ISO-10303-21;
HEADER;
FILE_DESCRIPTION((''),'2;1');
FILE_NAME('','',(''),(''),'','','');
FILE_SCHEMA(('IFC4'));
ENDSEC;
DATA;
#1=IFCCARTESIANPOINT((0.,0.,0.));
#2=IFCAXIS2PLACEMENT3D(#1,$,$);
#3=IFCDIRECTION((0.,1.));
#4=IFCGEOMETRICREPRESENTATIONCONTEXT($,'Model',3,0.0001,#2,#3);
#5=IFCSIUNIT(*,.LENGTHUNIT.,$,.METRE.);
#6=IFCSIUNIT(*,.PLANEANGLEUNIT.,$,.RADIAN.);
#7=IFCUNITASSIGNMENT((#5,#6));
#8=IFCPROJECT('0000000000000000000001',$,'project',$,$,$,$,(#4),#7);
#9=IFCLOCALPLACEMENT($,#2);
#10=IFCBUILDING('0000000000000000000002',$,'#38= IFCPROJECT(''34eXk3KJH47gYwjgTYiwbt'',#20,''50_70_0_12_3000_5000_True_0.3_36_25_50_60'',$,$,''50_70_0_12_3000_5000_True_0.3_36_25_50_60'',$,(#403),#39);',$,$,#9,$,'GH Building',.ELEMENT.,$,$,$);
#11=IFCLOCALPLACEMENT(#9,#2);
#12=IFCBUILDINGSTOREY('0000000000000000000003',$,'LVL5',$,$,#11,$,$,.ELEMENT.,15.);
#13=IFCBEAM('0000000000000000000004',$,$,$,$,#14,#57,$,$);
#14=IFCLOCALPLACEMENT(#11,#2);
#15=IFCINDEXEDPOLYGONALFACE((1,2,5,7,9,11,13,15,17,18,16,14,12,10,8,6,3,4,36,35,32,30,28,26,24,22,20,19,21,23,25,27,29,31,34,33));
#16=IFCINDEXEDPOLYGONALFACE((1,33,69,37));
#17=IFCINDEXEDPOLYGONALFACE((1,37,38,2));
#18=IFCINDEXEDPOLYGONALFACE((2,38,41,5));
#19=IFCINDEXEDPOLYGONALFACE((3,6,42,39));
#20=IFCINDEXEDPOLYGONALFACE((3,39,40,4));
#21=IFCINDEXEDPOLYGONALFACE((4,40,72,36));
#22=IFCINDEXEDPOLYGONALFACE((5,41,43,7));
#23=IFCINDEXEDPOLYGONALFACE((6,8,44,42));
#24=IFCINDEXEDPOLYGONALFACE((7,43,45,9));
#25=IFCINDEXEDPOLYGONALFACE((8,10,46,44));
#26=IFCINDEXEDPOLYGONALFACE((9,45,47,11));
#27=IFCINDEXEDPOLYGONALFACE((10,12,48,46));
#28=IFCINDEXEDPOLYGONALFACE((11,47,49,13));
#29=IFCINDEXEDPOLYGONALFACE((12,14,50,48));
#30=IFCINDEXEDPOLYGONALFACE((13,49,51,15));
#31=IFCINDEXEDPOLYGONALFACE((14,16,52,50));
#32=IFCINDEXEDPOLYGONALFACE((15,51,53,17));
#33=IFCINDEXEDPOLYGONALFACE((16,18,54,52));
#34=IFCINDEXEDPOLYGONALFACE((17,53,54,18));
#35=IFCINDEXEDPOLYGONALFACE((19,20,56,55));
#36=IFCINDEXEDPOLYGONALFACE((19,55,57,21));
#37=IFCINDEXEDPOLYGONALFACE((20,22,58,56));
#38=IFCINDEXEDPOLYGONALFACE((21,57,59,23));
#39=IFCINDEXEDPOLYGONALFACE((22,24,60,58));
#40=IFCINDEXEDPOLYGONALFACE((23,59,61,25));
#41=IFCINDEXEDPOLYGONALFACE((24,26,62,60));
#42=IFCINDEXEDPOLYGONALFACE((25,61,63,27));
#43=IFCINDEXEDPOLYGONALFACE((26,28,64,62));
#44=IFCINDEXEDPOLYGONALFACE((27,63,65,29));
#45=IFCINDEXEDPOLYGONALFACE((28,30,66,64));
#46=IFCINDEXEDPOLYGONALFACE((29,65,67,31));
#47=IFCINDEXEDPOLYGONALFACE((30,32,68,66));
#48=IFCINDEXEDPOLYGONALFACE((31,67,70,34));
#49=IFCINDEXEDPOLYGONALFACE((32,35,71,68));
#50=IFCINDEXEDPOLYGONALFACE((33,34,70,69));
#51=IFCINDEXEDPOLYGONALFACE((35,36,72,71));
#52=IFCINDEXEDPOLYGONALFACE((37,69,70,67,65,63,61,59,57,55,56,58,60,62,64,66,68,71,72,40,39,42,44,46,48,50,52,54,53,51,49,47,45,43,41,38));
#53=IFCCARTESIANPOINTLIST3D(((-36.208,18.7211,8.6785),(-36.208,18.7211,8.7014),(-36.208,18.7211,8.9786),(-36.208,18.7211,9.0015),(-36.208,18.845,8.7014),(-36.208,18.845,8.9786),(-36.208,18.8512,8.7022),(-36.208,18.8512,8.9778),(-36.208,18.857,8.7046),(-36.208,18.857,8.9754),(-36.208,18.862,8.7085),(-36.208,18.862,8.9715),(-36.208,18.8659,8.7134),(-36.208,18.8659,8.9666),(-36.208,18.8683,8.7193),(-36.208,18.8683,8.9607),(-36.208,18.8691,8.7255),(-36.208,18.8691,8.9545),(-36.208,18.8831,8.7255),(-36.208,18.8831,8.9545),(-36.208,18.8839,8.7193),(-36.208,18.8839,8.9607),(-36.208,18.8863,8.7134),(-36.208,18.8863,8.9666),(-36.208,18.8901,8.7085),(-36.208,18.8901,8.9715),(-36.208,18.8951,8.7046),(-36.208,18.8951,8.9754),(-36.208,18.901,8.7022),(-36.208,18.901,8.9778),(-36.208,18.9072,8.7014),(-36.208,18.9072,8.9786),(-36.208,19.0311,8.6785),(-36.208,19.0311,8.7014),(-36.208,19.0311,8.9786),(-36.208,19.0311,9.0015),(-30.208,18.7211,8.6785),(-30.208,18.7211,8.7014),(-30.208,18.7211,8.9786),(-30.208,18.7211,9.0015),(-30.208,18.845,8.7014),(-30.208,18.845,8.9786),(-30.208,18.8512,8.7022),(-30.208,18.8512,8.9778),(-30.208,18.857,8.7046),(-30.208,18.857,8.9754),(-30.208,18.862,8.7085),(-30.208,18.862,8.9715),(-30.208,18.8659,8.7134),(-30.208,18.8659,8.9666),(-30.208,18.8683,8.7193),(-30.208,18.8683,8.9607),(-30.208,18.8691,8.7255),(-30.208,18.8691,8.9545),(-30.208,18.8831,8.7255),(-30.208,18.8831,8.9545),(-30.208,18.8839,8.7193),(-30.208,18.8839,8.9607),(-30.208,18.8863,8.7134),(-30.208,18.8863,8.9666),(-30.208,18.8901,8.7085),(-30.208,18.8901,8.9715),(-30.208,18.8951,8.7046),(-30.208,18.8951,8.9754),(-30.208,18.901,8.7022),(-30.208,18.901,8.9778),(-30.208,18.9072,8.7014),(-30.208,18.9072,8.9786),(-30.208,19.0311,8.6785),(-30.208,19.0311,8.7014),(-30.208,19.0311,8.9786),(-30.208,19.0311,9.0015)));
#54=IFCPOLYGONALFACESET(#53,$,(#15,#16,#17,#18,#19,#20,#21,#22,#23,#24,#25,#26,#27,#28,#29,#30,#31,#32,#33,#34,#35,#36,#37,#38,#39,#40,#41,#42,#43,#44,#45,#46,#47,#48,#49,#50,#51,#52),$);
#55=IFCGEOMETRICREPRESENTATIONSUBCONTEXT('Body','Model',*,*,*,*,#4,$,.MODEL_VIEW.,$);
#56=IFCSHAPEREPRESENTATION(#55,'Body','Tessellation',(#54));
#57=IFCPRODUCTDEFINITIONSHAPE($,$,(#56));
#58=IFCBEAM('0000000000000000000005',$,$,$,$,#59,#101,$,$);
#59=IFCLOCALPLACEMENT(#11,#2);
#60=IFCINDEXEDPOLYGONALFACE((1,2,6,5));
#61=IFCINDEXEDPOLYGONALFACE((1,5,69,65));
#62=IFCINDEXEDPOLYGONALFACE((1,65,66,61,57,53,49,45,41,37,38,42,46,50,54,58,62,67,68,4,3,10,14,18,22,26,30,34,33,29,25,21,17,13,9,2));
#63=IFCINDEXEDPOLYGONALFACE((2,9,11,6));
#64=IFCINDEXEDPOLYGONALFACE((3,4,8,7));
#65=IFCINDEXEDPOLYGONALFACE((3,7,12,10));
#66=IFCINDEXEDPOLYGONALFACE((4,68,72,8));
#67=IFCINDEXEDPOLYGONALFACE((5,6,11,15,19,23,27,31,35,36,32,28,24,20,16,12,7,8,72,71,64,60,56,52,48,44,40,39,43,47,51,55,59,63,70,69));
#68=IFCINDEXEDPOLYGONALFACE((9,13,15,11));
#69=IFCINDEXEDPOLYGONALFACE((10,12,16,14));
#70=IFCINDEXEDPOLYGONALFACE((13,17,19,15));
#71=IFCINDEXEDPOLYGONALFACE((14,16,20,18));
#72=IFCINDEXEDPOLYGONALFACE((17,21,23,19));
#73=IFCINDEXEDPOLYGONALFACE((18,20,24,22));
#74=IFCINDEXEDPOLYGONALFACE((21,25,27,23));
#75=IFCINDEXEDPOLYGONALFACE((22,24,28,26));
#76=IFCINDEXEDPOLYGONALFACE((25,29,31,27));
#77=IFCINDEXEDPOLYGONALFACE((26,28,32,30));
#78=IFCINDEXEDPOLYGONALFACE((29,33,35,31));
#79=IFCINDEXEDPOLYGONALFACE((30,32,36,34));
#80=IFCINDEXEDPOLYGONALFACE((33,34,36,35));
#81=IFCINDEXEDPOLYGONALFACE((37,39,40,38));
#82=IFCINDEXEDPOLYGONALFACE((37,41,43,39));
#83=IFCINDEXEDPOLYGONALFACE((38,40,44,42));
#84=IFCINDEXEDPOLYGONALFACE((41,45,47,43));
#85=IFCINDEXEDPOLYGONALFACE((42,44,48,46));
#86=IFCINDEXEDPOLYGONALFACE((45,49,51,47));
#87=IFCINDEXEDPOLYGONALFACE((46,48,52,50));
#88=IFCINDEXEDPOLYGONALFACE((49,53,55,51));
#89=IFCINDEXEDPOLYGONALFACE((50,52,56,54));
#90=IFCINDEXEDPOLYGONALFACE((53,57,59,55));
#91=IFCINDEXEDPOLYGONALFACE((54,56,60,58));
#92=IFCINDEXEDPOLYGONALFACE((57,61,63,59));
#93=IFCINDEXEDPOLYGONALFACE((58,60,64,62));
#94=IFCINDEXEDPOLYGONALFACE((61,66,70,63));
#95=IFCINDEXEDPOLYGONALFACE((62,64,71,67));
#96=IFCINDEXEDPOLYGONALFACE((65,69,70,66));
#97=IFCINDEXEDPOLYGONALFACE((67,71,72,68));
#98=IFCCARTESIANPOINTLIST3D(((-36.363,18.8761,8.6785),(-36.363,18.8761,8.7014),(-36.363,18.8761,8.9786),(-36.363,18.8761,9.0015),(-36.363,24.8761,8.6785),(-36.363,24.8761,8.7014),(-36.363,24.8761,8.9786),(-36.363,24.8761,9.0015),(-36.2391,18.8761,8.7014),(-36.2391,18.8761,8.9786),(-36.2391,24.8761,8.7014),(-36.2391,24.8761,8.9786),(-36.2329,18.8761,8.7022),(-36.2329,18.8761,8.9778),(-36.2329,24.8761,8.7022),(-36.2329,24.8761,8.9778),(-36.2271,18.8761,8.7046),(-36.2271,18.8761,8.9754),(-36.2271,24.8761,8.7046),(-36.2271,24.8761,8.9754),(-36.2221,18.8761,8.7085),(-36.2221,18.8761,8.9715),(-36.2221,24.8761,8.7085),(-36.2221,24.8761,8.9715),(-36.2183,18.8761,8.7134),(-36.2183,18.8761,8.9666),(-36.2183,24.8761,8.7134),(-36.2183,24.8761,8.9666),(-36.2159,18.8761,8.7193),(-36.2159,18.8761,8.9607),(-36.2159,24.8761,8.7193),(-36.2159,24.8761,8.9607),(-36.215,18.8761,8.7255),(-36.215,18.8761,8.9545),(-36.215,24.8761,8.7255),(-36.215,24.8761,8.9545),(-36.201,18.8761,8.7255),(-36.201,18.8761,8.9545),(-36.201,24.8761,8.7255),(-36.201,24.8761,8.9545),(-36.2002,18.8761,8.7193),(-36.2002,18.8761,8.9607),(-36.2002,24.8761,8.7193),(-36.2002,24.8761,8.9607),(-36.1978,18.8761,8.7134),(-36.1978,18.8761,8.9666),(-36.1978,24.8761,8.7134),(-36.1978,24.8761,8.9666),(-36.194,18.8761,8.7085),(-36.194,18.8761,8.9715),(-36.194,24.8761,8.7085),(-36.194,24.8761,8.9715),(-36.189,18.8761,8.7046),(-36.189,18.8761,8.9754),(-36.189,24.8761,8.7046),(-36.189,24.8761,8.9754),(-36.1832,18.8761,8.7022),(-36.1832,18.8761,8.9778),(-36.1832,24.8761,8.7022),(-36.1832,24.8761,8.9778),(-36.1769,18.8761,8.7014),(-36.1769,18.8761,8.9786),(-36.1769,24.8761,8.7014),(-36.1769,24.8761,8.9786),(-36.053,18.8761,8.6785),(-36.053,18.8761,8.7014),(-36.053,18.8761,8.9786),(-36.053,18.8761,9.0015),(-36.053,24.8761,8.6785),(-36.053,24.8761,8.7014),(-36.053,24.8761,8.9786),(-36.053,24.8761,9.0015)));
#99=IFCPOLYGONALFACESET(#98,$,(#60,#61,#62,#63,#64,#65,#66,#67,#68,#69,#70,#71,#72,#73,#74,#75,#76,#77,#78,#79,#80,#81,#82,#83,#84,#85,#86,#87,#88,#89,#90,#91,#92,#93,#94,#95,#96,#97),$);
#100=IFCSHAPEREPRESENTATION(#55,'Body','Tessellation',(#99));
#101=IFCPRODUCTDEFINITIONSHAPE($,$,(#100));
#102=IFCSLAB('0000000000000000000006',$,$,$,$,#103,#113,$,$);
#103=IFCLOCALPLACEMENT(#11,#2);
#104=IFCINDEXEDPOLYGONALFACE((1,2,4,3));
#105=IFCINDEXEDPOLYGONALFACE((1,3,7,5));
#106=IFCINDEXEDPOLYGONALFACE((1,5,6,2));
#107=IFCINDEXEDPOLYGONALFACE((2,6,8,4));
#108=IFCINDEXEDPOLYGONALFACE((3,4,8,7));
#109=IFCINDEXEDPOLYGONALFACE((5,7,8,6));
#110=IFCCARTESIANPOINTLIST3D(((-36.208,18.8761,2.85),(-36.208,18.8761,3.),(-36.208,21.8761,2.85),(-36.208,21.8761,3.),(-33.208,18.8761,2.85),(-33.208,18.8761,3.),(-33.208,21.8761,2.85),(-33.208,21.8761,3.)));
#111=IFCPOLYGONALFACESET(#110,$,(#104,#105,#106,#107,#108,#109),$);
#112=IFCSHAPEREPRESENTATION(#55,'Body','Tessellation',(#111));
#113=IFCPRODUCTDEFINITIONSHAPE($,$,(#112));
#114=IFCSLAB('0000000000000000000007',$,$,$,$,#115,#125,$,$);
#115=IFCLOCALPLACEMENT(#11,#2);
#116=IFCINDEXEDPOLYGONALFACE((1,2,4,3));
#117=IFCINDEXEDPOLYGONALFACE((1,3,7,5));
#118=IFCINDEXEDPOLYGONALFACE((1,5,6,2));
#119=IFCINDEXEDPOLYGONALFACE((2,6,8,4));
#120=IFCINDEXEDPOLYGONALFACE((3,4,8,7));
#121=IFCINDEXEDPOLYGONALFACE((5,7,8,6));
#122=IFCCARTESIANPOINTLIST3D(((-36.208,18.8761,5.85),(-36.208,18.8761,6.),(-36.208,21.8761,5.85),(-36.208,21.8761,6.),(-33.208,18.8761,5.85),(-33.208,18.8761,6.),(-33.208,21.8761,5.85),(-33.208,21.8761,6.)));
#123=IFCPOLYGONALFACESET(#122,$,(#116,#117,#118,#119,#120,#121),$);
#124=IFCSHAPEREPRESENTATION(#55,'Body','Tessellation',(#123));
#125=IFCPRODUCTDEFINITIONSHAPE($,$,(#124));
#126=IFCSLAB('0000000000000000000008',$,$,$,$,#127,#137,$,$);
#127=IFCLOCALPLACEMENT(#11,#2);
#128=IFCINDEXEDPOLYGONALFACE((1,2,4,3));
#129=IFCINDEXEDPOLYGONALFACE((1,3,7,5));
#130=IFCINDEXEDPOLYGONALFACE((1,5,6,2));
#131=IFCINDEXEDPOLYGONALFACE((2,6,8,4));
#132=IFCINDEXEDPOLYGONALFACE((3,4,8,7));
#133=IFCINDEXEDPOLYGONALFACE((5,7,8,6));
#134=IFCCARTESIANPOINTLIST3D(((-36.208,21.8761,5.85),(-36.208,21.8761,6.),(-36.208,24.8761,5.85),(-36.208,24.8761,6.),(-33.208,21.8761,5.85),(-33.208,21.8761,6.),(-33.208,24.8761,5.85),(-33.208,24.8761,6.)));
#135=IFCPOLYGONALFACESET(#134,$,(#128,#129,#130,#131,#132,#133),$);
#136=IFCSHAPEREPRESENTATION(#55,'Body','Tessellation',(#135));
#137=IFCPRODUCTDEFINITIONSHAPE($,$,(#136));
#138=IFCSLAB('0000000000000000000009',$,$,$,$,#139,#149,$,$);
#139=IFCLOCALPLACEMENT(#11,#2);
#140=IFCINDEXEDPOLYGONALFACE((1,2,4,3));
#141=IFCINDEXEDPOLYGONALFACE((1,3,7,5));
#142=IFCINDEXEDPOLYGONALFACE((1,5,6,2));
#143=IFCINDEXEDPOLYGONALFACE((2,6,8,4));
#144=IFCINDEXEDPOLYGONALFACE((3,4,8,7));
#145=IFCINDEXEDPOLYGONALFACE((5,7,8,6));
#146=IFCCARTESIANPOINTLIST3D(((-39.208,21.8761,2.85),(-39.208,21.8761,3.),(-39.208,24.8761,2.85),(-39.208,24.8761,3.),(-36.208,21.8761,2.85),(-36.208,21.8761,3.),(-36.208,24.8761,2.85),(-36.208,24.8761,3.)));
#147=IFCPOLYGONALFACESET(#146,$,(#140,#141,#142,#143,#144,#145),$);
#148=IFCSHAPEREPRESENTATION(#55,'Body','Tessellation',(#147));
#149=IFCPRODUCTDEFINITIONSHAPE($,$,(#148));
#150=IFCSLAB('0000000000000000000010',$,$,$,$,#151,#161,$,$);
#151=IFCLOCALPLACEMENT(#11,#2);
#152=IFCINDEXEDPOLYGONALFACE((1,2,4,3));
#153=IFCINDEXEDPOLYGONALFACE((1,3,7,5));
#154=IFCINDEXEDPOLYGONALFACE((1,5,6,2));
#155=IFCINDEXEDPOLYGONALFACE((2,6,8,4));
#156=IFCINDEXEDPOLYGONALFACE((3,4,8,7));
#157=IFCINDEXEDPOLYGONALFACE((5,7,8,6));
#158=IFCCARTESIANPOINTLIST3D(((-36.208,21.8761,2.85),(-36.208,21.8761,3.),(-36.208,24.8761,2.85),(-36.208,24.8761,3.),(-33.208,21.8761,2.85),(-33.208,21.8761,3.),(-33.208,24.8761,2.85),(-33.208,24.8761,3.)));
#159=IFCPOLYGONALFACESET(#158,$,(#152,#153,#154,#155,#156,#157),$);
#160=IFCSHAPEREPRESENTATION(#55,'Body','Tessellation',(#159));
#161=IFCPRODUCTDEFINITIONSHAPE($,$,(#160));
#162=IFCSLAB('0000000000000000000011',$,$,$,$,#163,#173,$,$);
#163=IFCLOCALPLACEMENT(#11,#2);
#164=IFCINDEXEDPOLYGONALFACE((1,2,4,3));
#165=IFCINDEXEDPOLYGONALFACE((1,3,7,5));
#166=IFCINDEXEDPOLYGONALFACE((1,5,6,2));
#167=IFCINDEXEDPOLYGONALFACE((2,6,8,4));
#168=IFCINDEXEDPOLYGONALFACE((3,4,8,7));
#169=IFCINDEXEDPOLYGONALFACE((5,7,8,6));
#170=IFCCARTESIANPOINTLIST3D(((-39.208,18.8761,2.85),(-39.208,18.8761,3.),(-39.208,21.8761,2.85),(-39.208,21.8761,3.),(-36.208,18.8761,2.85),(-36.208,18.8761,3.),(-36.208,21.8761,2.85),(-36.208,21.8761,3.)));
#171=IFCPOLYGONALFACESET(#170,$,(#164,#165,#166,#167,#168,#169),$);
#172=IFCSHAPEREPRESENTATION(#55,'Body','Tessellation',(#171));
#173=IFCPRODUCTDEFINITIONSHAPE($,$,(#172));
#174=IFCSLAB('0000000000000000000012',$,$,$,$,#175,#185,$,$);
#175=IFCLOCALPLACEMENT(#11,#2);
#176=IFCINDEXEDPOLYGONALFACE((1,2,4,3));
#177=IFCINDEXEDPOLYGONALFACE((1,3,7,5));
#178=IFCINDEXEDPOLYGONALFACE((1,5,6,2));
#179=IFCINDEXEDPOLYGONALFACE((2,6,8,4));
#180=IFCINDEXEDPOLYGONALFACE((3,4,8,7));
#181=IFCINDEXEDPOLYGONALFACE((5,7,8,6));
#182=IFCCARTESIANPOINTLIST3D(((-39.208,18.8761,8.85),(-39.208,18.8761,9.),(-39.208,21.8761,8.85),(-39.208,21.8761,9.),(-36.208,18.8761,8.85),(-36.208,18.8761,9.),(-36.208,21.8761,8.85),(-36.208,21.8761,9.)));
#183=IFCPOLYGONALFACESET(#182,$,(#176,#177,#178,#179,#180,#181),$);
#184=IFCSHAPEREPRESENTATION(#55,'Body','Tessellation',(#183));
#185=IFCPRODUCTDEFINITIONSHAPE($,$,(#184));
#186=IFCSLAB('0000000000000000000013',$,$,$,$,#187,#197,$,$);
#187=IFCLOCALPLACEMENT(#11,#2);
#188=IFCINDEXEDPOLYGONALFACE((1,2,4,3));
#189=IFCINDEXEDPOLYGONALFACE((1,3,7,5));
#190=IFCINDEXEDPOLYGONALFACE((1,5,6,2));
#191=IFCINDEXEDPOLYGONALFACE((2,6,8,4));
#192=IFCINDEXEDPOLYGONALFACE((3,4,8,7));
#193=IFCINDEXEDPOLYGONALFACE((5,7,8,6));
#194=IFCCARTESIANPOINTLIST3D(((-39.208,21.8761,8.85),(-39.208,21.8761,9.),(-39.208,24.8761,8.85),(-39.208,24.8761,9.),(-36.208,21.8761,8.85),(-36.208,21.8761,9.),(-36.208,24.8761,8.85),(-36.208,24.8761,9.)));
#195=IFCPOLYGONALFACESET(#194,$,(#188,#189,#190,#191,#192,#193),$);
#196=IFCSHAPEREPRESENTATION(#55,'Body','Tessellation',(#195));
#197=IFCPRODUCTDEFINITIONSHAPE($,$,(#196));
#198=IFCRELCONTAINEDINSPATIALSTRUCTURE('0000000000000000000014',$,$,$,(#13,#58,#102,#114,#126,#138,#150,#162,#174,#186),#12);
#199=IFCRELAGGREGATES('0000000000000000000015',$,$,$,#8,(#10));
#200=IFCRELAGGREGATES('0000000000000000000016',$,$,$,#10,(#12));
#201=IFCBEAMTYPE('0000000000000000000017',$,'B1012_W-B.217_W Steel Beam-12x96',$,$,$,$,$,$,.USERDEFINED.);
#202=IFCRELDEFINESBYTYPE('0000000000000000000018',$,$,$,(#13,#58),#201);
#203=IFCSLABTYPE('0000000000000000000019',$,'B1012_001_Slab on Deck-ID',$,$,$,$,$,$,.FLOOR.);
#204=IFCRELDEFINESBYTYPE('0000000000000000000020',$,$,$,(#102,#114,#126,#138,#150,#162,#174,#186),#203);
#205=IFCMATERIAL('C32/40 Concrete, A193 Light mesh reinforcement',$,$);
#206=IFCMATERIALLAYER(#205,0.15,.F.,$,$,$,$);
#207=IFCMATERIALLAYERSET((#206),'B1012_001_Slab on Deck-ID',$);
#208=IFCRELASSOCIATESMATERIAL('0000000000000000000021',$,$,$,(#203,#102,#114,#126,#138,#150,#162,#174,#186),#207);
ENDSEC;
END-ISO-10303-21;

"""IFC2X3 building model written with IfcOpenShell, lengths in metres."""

from ifc_helpers import new_model, si_unit, direction, frame, origin, origin_2d, place, context, subcontext, project, spatial, polyline, i_section, outline, extrude, material, layer, layer_set, layer_usage, type_object, element, save


model = new_model("IFC2X3")

# Units and contexts
model_context = context("Model", 3, precision=0.0001, world=origin(), true_north=direction((0.0, 1.0)))
body_context = subcontext(model_context, "Body", "Model", "MODEL_VIEW")
ifc_project = project(units=[si_unit("LENGTHUNIT", "METRE"), si_unit("PLANEANGLEUNIT", "RADIAN")], contexts=[model_context])

# Building, storey
building_placement = place(None, origin())
building = spatial("IfcBuilding", under=ifc_project, at=building_placement, Name="#38= IFCPROJECT('34eXk3KJH47gYwjgTYiwbt',#20,'50_70_0_12_3000_5000_True_0.3_36_25_50_60',$,$,'50_70_0_12_3000_5000_True_0.3_36_25_50_60',$,(#403),#39);", LongName="GH Building", CompositionType="ELEMENT")
storey_placement = place(building_placement, origin())
storey = spatial("IfcBuildingStorey", under=building, at=storey_placement, Name="LVL5", CompositionType="ELEMENT", Elevation=15.0)

# Beams
beam_type = type_object("IfcBeamType", Name="B1012_W-B.217_W Steel Beam-12x96", PredefinedType="USERDEFINED")
for number, where, z_axis, x_axis in (
    (1, (-36.208, 18.8761, 8.84), (1.0, 0.0, 0.0), (0.0, 1.0, 0.0)),
    (2, (-36.208, 18.8761, 8.84), (0.0, 1.0, 0.0), (-1.0, 0.0, 0.0)),
):
    element("IfcBeam", number, at=place(storey_placement, frame(where, z_axis=z_axis, x_axis=x_axis)), inside=storey, type_object=beam_type, context=body_context, shape_type="SweptSolid", body=[
        extrude(i_section(OverallWidth=0.31, OverallDepth=0.323, WebThickness=0.014, FlangeThickness=0.0229, FilletRadius=0.0241, at=origin_2d()), origin(), (0.0, 0.0, 1.0), 6.0),
    ])

# Slabs
ifc_material_1 = material(Name="C32/40 Concrete, A193 Light mesh reinforcement")
ifc_layer_1 = layer(ifc_material_1, 0.15, ventilated=False)
ifc_layer_set_1 = layer_set([ifc_layer_1], Name="B1012_001_Slab on Deck-ID")
ifc_layer_usage_1 = layer_usage(ifc_layer_set_1, "AXIS3", "NEGATIVE", -0.15)
slab_type_1 = type_object("IfcSlabType", Name="B1012_001_Slab on Deck-ID", PredefinedType="FLOOR", material=ifc_layer_set_1)
slab_1_placement = place(storey_placement, frame((-34.708, 20.3761, 2.85), z_axis=(0.0, 0.0, 1.0), x_axis=(0.0, 1.0, 0.0)))
element("IfcSlab", 3, at=slab_1_placement, inside=storey, type_object=slab_type_1, material=ifc_layer_usage_1, context=body_context, shape_type="SweptSolid", body=[
    extrude(outline(polyline([(-1.5, -1.5), (1.5, -1.5), (1.5, 1.5), (-1.5, 1.5), (-1.5, -1.5)])), origin(), (0.0, 0.0, 1.0), 0.15),
])
ifc_layer_usage_2 = layer_usage(ifc_layer_set_1, "AXIS3", "NEGATIVE", -0.15)
slab_2_placement = place(storey_placement, frame((-34.708, 20.3761, 5.85)))
element("IfcSlab", 4, at=slab_2_placement, inside=storey, type_object=slab_type_1, material=ifc_layer_usage_2, context=body_context, shape_type="SweptSolid", body=[
    extrude(outline(polyline([(1.5, -1.5), (-1.5, -1.5), (-1.5, 1.5), (1.5, 1.5), (1.5, -1.5)])), origin(), (0.0, 0.0, 1.0), 0.15),
])
ifc_layer_usage_3 = layer_usage(ifc_layer_set_1, "AXIS3", "NEGATIVE", -0.15)
slab_3_placement = place(storey_placement, frame((-34.708, 23.3761, 5.85)))
element("IfcSlab", 5, at=slab_3_placement, inside=storey, type_object=slab_type_1, material=ifc_layer_usage_3, context=body_context, shape_type="SweptSolid", body=[
    extrude(outline(polyline([(1.5, -1.5), (-1.5, -1.5), (-1.5, 1.5), (1.5, 1.5), (1.5, -1.5)])), origin(), (0.0, 0.0, 1.0), 0.15),
])
ifc_layer_usage_4 = layer_usage(ifc_layer_set_1, "AXIS3", "NEGATIVE", -0.15)
slab_4_placement = place(storey_placement, frame((-37.708, 23.3761, 2.85)))
element("IfcSlab", 6, at=slab_4_placement, inside=storey, type_object=slab_type_1, material=ifc_layer_usage_4, context=body_context, shape_type="SweptSolid", body=[
    extrude(outline(polyline([(-1.5, -1.5), (-1.5, 1.5), (1.5, 1.5), (1.5, -1.5), (-1.5, -1.5)])), origin(), (0.0, 0.0, 1.0), 0.15),
])
ifc_layer_usage_5 = layer_usage(ifc_layer_set_1, "AXIS3", "NEGATIVE", -0.15)
slab_5_placement = place(storey_placement, frame((-34.708, 23.3761, 2.85), z_axis=(0.0, 0.0, 1.0), x_axis=(0.0, 1.0, 0.0)))
element("IfcSlab", 7, at=slab_5_placement, inside=storey, type_object=slab_type_1, material=ifc_layer_usage_5, context=body_context, shape_type="SweptSolid", body=[
    extrude(outline(polyline([(-1.5, -1.5), (1.5, -1.5), (1.5, 1.5), (-1.5, 1.5), (-1.5, -1.5)])), origin(), (0.0, 0.0, 1.0), 0.15),
])
ifc_layer_usage_6 = layer_usage(ifc_layer_set_1, "AXIS3", "NEGATIVE", -0.15)
slab_6_placement = place(storey_placement, frame((-37.708, 20.3761, 2.85), z_axis=(0.0, 0.0, 1.0), x_axis=(0.0, 1.0, 0.0)))
element("IfcSlab", 8, at=slab_6_placement, inside=storey, type_object=slab_type_1, material=ifc_layer_usage_6, context=body_context, shape_type="SweptSolid", body=[
    extrude(outline(polyline([(-1.5, -1.5), (1.5, -1.5), (1.5, 1.5), (-1.5, 1.5), (-1.5, -1.5)])), origin(), (0.0, 0.0, 1.0), 0.15),
])
ifc_layer_usage_7 = layer_usage(ifc_layer_set_1, "AXIS3", "NEGATIVE", -0.15)
slab_7_placement = place(storey_placement, frame((-37.708, 20.3761, 8.85)))
element("IfcSlab", 9, at=slab_7_placement, inside=storey, type_object=slab_type_1, material=ifc_layer_usage_7, context=body_context, shape_type="SweptSolid", body=[
    extrude(outline(polyline([(1.5, -1.5), (-1.5, -1.5), (-1.5, 1.5), (1.5, 1.5), (1.5, -1.5)])), origin(), (0.0, 0.0, 1.0), 0.15),
])
ifc_layer_usage_8 = layer_usage(ifc_layer_set_1, "AXIS3", "NEGATIVE", -0.15)
slab_8_placement = place(storey_placement, frame((-37.708, 23.3761, 8.85)))
element("IfcSlab", 10, at=slab_8_placement, inside=storey, type_object=slab_type_1, material=ifc_layer_usage_8, context=body_context, shape_type="SweptSolid", body=[
    extrude(outline(polyline([(1.5, -1.5), (-1.5, -1.5), (-1.5, 1.5), (1.5, 1.5), (1.5, -1.5)])), origin(), (0.0, 0.0, 1.0), 0.15),
])

save(model, "model.ifc")
